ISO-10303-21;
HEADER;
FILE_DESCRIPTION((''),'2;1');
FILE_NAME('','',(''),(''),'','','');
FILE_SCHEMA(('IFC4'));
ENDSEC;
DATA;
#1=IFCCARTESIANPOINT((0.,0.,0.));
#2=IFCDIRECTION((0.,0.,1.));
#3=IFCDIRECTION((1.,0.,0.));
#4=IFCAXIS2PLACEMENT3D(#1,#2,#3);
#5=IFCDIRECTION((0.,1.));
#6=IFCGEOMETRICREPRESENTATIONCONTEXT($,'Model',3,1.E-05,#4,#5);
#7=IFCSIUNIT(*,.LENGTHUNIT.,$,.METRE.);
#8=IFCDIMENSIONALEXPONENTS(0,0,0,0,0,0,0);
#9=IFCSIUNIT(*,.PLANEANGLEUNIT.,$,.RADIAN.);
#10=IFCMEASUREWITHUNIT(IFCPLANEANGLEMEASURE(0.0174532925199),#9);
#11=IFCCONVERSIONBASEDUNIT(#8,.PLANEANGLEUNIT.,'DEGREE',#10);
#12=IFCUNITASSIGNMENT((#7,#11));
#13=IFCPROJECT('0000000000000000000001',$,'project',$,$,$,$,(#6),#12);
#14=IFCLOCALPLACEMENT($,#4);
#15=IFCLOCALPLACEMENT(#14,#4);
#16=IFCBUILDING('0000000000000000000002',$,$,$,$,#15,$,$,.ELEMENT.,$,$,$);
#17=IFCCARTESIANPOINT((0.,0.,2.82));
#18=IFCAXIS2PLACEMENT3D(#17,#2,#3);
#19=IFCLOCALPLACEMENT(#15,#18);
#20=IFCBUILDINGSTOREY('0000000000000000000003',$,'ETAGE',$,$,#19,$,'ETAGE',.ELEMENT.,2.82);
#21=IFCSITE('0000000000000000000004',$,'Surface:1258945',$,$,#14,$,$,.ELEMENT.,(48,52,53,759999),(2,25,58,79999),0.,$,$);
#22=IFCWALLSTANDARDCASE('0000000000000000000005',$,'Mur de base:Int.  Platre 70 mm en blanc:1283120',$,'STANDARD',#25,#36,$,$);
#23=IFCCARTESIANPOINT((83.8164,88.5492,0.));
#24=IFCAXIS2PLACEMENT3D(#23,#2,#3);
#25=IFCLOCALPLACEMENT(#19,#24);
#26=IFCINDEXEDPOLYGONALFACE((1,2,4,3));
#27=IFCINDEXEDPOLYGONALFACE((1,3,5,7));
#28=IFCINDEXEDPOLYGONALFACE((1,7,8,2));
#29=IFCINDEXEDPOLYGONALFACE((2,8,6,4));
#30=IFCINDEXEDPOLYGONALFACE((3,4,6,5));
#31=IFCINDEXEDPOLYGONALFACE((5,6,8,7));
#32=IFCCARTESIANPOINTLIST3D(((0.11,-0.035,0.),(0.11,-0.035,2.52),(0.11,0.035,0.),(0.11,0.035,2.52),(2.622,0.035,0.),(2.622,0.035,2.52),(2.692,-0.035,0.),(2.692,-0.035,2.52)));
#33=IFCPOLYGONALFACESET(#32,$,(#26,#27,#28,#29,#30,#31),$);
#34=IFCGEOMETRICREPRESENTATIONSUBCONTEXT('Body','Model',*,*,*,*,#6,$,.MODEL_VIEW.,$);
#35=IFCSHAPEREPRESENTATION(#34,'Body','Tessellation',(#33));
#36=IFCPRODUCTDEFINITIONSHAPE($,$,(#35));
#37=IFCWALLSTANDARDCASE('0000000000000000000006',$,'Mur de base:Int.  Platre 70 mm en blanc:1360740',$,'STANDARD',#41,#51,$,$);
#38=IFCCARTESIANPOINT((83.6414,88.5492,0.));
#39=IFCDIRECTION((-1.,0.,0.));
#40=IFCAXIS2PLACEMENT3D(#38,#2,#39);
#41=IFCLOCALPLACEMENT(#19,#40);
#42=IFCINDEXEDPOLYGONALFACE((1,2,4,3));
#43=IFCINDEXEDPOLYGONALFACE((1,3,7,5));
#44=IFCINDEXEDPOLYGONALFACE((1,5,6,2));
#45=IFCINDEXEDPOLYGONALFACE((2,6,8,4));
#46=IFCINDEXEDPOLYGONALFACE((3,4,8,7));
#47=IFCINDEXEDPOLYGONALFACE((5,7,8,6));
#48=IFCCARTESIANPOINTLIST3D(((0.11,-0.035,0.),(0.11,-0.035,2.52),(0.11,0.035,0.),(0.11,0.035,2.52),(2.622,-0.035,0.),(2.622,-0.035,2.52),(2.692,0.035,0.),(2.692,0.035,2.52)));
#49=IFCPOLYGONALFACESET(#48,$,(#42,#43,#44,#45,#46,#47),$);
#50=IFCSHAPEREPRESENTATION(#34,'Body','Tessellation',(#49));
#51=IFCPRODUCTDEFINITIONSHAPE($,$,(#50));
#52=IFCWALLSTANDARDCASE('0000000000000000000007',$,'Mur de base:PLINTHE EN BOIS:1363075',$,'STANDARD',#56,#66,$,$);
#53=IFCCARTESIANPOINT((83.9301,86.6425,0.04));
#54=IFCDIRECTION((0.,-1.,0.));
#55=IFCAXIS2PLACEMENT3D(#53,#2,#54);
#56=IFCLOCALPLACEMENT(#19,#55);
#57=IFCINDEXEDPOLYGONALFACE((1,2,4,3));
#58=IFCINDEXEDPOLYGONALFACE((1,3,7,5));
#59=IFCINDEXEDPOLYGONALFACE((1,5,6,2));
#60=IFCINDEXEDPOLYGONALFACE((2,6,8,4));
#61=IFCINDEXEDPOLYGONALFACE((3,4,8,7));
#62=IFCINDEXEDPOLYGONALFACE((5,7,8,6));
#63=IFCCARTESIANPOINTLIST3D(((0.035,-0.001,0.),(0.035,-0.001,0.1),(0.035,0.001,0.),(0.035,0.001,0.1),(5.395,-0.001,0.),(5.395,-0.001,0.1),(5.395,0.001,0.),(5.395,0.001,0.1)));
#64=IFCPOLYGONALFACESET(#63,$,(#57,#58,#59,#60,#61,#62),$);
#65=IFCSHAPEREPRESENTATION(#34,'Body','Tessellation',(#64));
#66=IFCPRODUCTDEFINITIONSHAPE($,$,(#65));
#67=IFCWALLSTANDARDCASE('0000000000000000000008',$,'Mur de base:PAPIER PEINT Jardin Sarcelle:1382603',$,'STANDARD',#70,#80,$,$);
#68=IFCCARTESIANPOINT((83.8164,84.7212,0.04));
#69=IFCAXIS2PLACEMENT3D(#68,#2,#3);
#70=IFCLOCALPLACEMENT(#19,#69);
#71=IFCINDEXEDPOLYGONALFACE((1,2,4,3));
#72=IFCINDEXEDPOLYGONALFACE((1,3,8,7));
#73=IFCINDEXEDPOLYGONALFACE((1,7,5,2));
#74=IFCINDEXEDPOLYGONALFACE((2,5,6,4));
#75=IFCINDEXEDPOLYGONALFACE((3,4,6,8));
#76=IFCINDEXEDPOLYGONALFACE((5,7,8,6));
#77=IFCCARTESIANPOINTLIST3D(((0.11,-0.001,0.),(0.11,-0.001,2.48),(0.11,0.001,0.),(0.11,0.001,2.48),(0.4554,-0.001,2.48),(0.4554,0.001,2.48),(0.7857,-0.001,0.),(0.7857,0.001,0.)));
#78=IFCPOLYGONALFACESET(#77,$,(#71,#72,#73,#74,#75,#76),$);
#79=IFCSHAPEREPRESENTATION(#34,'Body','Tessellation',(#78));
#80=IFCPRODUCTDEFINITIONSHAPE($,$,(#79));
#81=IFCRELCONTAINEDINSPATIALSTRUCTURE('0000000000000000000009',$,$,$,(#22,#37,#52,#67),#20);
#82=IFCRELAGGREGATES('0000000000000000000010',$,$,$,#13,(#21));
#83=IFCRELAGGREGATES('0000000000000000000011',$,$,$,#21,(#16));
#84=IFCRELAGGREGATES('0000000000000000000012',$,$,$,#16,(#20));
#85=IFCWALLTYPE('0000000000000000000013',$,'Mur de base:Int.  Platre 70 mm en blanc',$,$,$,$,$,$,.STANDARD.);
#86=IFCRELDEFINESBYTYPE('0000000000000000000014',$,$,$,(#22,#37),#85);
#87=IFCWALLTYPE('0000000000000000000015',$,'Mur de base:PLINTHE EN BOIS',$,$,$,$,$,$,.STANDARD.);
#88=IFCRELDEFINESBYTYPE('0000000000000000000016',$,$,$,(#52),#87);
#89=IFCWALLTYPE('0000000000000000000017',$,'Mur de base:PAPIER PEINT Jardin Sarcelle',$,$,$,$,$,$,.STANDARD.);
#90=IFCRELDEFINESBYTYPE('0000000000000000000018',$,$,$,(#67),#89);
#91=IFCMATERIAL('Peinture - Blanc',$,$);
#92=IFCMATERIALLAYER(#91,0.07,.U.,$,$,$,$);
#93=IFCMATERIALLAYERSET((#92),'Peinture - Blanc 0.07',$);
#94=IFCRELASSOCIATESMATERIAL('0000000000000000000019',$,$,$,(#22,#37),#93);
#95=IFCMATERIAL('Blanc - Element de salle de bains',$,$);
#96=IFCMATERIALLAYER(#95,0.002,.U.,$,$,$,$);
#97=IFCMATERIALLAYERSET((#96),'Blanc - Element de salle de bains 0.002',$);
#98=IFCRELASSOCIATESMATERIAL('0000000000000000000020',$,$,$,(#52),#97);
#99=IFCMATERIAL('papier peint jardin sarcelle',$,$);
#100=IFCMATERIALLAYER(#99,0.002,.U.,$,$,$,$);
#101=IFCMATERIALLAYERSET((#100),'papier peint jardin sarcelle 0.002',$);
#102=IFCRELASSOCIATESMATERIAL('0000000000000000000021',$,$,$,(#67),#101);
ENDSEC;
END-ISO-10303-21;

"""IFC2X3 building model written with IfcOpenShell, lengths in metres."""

from ifc_helpers import new_model, entity, si_unit, converted_unit, direction, frame, origin_with_axes, place, context, subcontext, project, spatial, polyline, outline, extrude, clip, halfspace, material, layer, layer_set, layer_usage, type_object, element, save


model = new_model("IFC2X3")

# Units and contexts
model_context = context("Model", 3, precision=1e-05, world=origin_with_axes(), true_north=direction((0.0, 1.0)))
body_context = subcontext(model_context, "Body", "Model", "MODEL_VIEW")
ifc_project = project(units=[si_unit("LENGTHUNIT", "METRE"), converted_unit("PLANEANGLEUNIT", "DEGREE", entity("IfcPlaneAngleMeasure", 0.0174532925199), si_unit("PLANEANGLEUNIT", "RADIAN"), dimensions=[0, 0, 0, 0, 0, 0, 0])], contexts=[model_context])

# Site, building, storey
site_placement = place(None, origin_with_axes())
site = spatial("IfcSite", under=ifc_project, at=site_placement, Name="Surface:1258945", CompositionType="ELEMENT", RefLatitude=(48, 52, 53, 759999), RefLongitude=(2, 25, 58, 79999), RefElevation=0.0)
building_placement = place(site_placement, origin_with_axes())
building = spatial("IfcBuilding", under=site, at=building_placement, CompositionType="ELEMENT")
storey_placement = place(building_placement, frame((0.0, 0.0, 2.82), z_axis=(0.0, 0.0, 1.0), x_axis=(1.0, 0.0, 0.0)))
storey = spatial("IfcBuildingStorey", under=building, at=storey_placement, Name="ETAGE", LongName="ETAGE", CompositionType="ELEMENT", Elevation=2.82)

# Walls
ifc_material_1 = material(Name="Peinture - Blanc")
ifc_layer_1 = layer(ifc_material_1, 0.07, ventilated="UNKNOWN")
ifc_layer_set_1 = layer_set([ifc_layer_1], Name="Peinture - Blanc 0.07")
ifc_layer_usage_1 = layer_usage(ifc_layer_set_1, "AXIS2", "POSITIVE", -0.035)
wall_type_1 = type_object("IfcWallType", Name="Mur de base:Int.  Platre 70 mm en blanc", PredefinedType="STANDARD")
wall_1_placement = place(storey_placement, frame((83.8164, 88.5492, 0.0), z_axis=(0.0, 0.0, 1.0), x_axis=(1.0, 0.0, 0.0)))
element("IfcWallStandardCase", 1, at=wall_1_placement, inside=storey, type_object=wall_type_1, material=ifc_layer_usage_1, Name="Mur de base:Int.  Platre 70 mm en blanc:1283120", ObjectType="STANDARD", context=body_context, shape_type="SweptSolid", body=[
    extrude(outline(polyline([(0.11, -0.035), (2.692, -0.035), (2.622, 0.035), (0.11, 0.035), (0.11, -0.035)])), origin_with_axes(), (0.0, 0.0, 1.0), 2.52),
])
ifc_layer_usage_2 = layer_usage(ifc_layer_set_1, "AXIS2", "POSITIVE", -0.035)
wall_2_placement = place(storey_placement, frame((83.6414, 88.5492, 0.0), z_axis=(0.0, 0.0, 1.0), x_axis=(-1.0, 0.0, 0.0)))
element("IfcWallStandardCase", 2, at=wall_2_placement, inside=storey, type_object=wall_type_1, material=ifc_layer_usage_2, Name="Mur de base:Int.  Platre 70 mm en blanc:1360740", ObjectType="STANDARD", context=body_context, shape_type="SweptSolid", body=[
    extrude(outline(polyline([(0.11, -0.035), (2.622, -0.035), (2.692, 0.035), (0.11, 0.035), (0.11, -0.035)])), origin_with_axes(), (0.0, 0.0, 1.0), 2.52),
])
ifc_material_2 = material(Name="Blanc - Element de salle de bains")
ifc_layer_2 = layer(ifc_material_2, 0.002, ventilated="UNKNOWN")
ifc_layer_set_2 = layer_set([ifc_layer_2], Name="Blanc - Element de salle de bains 0.002")
ifc_layer_usage_3 = layer_usage(ifc_layer_set_2, "AXIS2", "POSITIVE", -0.001)
wall_type_2 = type_object("IfcWallType", Name="Mur de base:PLINTHE EN BOIS", PredefinedType="STANDARD")
wall_3_placement = place(storey_placement, frame((83.9301, 86.6425, 0.04), z_axis=(0.0, 0.0, 1.0), x_axis=(0.0, -1.0, 0.0)))
element("IfcWallStandardCase", 3, at=wall_3_placement, inside=storey, type_object=wall_type_2, material=ifc_layer_usage_3, Name="Mur de base:PLINTHE EN BOIS:1363075", ObjectType="STANDARD", context=body_context, shape_type="SweptSolid", body=[
    extrude(outline(polyline([(0.035, -0.001), (5.395, -0.001), (5.395, 0.001), (0.035, 0.001), (0.035, -0.001)])), origin_with_axes(), (0.0, 0.0, 1.0), 0.1),
])
ifc_material_3 = material(Name="papier peint jardin sarcelle")
ifc_layer_3 = layer(ifc_material_3, 0.002, ventilated="UNKNOWN")
ifc_layer_set_3 = layer_set([ifc_layer_3], Name="papier peint jardin sarcelle 0.002")
ifc_layer_usage_4 = layer_usage(ifc_layer_set_3, "AXIS2", "POSITIVE", -0.001)
wall_type_3 = type_object("IfcWallType", Name="Mur de base:PAPIER PEINT Jardin Sarcelle", PredefinedType="STANDARD")
wall_4_placement = place(storey_placement, frame((83.8164, 84.7212, 0.04), z_axis=(0.0, 0.0, 1.0), x_axis=(1.0, 0.0, 0.0)))
element("IfcWallStandardCase", 4, at=wall_4_placement, inside=storey, type_object=wall_type_3, material=ifc_layer_usage_4, Name="Mur de base:PAPIER PEINT Jardin Sarcelle:1382603", ObjectType="STANDARD", context=body_context, shape_type="Clipping", body=[
    clip(extrude(outline(polyline([(0.11, -0.001), (0.7857, -0.001), (0.7857, 0.001), (0.11, 0.001), (0.11, -0.001)])), origin_with_axes(), (0.0, 0.0, 1.0), 2.48), halfspace(frame((0.772, 0.0, 0.1028), z_axis=(-0.991252, 0.0, -0.131985), x_axis=(0.0, 1.0, 0.0)), True)),
])

save(model, "model.ifc")
